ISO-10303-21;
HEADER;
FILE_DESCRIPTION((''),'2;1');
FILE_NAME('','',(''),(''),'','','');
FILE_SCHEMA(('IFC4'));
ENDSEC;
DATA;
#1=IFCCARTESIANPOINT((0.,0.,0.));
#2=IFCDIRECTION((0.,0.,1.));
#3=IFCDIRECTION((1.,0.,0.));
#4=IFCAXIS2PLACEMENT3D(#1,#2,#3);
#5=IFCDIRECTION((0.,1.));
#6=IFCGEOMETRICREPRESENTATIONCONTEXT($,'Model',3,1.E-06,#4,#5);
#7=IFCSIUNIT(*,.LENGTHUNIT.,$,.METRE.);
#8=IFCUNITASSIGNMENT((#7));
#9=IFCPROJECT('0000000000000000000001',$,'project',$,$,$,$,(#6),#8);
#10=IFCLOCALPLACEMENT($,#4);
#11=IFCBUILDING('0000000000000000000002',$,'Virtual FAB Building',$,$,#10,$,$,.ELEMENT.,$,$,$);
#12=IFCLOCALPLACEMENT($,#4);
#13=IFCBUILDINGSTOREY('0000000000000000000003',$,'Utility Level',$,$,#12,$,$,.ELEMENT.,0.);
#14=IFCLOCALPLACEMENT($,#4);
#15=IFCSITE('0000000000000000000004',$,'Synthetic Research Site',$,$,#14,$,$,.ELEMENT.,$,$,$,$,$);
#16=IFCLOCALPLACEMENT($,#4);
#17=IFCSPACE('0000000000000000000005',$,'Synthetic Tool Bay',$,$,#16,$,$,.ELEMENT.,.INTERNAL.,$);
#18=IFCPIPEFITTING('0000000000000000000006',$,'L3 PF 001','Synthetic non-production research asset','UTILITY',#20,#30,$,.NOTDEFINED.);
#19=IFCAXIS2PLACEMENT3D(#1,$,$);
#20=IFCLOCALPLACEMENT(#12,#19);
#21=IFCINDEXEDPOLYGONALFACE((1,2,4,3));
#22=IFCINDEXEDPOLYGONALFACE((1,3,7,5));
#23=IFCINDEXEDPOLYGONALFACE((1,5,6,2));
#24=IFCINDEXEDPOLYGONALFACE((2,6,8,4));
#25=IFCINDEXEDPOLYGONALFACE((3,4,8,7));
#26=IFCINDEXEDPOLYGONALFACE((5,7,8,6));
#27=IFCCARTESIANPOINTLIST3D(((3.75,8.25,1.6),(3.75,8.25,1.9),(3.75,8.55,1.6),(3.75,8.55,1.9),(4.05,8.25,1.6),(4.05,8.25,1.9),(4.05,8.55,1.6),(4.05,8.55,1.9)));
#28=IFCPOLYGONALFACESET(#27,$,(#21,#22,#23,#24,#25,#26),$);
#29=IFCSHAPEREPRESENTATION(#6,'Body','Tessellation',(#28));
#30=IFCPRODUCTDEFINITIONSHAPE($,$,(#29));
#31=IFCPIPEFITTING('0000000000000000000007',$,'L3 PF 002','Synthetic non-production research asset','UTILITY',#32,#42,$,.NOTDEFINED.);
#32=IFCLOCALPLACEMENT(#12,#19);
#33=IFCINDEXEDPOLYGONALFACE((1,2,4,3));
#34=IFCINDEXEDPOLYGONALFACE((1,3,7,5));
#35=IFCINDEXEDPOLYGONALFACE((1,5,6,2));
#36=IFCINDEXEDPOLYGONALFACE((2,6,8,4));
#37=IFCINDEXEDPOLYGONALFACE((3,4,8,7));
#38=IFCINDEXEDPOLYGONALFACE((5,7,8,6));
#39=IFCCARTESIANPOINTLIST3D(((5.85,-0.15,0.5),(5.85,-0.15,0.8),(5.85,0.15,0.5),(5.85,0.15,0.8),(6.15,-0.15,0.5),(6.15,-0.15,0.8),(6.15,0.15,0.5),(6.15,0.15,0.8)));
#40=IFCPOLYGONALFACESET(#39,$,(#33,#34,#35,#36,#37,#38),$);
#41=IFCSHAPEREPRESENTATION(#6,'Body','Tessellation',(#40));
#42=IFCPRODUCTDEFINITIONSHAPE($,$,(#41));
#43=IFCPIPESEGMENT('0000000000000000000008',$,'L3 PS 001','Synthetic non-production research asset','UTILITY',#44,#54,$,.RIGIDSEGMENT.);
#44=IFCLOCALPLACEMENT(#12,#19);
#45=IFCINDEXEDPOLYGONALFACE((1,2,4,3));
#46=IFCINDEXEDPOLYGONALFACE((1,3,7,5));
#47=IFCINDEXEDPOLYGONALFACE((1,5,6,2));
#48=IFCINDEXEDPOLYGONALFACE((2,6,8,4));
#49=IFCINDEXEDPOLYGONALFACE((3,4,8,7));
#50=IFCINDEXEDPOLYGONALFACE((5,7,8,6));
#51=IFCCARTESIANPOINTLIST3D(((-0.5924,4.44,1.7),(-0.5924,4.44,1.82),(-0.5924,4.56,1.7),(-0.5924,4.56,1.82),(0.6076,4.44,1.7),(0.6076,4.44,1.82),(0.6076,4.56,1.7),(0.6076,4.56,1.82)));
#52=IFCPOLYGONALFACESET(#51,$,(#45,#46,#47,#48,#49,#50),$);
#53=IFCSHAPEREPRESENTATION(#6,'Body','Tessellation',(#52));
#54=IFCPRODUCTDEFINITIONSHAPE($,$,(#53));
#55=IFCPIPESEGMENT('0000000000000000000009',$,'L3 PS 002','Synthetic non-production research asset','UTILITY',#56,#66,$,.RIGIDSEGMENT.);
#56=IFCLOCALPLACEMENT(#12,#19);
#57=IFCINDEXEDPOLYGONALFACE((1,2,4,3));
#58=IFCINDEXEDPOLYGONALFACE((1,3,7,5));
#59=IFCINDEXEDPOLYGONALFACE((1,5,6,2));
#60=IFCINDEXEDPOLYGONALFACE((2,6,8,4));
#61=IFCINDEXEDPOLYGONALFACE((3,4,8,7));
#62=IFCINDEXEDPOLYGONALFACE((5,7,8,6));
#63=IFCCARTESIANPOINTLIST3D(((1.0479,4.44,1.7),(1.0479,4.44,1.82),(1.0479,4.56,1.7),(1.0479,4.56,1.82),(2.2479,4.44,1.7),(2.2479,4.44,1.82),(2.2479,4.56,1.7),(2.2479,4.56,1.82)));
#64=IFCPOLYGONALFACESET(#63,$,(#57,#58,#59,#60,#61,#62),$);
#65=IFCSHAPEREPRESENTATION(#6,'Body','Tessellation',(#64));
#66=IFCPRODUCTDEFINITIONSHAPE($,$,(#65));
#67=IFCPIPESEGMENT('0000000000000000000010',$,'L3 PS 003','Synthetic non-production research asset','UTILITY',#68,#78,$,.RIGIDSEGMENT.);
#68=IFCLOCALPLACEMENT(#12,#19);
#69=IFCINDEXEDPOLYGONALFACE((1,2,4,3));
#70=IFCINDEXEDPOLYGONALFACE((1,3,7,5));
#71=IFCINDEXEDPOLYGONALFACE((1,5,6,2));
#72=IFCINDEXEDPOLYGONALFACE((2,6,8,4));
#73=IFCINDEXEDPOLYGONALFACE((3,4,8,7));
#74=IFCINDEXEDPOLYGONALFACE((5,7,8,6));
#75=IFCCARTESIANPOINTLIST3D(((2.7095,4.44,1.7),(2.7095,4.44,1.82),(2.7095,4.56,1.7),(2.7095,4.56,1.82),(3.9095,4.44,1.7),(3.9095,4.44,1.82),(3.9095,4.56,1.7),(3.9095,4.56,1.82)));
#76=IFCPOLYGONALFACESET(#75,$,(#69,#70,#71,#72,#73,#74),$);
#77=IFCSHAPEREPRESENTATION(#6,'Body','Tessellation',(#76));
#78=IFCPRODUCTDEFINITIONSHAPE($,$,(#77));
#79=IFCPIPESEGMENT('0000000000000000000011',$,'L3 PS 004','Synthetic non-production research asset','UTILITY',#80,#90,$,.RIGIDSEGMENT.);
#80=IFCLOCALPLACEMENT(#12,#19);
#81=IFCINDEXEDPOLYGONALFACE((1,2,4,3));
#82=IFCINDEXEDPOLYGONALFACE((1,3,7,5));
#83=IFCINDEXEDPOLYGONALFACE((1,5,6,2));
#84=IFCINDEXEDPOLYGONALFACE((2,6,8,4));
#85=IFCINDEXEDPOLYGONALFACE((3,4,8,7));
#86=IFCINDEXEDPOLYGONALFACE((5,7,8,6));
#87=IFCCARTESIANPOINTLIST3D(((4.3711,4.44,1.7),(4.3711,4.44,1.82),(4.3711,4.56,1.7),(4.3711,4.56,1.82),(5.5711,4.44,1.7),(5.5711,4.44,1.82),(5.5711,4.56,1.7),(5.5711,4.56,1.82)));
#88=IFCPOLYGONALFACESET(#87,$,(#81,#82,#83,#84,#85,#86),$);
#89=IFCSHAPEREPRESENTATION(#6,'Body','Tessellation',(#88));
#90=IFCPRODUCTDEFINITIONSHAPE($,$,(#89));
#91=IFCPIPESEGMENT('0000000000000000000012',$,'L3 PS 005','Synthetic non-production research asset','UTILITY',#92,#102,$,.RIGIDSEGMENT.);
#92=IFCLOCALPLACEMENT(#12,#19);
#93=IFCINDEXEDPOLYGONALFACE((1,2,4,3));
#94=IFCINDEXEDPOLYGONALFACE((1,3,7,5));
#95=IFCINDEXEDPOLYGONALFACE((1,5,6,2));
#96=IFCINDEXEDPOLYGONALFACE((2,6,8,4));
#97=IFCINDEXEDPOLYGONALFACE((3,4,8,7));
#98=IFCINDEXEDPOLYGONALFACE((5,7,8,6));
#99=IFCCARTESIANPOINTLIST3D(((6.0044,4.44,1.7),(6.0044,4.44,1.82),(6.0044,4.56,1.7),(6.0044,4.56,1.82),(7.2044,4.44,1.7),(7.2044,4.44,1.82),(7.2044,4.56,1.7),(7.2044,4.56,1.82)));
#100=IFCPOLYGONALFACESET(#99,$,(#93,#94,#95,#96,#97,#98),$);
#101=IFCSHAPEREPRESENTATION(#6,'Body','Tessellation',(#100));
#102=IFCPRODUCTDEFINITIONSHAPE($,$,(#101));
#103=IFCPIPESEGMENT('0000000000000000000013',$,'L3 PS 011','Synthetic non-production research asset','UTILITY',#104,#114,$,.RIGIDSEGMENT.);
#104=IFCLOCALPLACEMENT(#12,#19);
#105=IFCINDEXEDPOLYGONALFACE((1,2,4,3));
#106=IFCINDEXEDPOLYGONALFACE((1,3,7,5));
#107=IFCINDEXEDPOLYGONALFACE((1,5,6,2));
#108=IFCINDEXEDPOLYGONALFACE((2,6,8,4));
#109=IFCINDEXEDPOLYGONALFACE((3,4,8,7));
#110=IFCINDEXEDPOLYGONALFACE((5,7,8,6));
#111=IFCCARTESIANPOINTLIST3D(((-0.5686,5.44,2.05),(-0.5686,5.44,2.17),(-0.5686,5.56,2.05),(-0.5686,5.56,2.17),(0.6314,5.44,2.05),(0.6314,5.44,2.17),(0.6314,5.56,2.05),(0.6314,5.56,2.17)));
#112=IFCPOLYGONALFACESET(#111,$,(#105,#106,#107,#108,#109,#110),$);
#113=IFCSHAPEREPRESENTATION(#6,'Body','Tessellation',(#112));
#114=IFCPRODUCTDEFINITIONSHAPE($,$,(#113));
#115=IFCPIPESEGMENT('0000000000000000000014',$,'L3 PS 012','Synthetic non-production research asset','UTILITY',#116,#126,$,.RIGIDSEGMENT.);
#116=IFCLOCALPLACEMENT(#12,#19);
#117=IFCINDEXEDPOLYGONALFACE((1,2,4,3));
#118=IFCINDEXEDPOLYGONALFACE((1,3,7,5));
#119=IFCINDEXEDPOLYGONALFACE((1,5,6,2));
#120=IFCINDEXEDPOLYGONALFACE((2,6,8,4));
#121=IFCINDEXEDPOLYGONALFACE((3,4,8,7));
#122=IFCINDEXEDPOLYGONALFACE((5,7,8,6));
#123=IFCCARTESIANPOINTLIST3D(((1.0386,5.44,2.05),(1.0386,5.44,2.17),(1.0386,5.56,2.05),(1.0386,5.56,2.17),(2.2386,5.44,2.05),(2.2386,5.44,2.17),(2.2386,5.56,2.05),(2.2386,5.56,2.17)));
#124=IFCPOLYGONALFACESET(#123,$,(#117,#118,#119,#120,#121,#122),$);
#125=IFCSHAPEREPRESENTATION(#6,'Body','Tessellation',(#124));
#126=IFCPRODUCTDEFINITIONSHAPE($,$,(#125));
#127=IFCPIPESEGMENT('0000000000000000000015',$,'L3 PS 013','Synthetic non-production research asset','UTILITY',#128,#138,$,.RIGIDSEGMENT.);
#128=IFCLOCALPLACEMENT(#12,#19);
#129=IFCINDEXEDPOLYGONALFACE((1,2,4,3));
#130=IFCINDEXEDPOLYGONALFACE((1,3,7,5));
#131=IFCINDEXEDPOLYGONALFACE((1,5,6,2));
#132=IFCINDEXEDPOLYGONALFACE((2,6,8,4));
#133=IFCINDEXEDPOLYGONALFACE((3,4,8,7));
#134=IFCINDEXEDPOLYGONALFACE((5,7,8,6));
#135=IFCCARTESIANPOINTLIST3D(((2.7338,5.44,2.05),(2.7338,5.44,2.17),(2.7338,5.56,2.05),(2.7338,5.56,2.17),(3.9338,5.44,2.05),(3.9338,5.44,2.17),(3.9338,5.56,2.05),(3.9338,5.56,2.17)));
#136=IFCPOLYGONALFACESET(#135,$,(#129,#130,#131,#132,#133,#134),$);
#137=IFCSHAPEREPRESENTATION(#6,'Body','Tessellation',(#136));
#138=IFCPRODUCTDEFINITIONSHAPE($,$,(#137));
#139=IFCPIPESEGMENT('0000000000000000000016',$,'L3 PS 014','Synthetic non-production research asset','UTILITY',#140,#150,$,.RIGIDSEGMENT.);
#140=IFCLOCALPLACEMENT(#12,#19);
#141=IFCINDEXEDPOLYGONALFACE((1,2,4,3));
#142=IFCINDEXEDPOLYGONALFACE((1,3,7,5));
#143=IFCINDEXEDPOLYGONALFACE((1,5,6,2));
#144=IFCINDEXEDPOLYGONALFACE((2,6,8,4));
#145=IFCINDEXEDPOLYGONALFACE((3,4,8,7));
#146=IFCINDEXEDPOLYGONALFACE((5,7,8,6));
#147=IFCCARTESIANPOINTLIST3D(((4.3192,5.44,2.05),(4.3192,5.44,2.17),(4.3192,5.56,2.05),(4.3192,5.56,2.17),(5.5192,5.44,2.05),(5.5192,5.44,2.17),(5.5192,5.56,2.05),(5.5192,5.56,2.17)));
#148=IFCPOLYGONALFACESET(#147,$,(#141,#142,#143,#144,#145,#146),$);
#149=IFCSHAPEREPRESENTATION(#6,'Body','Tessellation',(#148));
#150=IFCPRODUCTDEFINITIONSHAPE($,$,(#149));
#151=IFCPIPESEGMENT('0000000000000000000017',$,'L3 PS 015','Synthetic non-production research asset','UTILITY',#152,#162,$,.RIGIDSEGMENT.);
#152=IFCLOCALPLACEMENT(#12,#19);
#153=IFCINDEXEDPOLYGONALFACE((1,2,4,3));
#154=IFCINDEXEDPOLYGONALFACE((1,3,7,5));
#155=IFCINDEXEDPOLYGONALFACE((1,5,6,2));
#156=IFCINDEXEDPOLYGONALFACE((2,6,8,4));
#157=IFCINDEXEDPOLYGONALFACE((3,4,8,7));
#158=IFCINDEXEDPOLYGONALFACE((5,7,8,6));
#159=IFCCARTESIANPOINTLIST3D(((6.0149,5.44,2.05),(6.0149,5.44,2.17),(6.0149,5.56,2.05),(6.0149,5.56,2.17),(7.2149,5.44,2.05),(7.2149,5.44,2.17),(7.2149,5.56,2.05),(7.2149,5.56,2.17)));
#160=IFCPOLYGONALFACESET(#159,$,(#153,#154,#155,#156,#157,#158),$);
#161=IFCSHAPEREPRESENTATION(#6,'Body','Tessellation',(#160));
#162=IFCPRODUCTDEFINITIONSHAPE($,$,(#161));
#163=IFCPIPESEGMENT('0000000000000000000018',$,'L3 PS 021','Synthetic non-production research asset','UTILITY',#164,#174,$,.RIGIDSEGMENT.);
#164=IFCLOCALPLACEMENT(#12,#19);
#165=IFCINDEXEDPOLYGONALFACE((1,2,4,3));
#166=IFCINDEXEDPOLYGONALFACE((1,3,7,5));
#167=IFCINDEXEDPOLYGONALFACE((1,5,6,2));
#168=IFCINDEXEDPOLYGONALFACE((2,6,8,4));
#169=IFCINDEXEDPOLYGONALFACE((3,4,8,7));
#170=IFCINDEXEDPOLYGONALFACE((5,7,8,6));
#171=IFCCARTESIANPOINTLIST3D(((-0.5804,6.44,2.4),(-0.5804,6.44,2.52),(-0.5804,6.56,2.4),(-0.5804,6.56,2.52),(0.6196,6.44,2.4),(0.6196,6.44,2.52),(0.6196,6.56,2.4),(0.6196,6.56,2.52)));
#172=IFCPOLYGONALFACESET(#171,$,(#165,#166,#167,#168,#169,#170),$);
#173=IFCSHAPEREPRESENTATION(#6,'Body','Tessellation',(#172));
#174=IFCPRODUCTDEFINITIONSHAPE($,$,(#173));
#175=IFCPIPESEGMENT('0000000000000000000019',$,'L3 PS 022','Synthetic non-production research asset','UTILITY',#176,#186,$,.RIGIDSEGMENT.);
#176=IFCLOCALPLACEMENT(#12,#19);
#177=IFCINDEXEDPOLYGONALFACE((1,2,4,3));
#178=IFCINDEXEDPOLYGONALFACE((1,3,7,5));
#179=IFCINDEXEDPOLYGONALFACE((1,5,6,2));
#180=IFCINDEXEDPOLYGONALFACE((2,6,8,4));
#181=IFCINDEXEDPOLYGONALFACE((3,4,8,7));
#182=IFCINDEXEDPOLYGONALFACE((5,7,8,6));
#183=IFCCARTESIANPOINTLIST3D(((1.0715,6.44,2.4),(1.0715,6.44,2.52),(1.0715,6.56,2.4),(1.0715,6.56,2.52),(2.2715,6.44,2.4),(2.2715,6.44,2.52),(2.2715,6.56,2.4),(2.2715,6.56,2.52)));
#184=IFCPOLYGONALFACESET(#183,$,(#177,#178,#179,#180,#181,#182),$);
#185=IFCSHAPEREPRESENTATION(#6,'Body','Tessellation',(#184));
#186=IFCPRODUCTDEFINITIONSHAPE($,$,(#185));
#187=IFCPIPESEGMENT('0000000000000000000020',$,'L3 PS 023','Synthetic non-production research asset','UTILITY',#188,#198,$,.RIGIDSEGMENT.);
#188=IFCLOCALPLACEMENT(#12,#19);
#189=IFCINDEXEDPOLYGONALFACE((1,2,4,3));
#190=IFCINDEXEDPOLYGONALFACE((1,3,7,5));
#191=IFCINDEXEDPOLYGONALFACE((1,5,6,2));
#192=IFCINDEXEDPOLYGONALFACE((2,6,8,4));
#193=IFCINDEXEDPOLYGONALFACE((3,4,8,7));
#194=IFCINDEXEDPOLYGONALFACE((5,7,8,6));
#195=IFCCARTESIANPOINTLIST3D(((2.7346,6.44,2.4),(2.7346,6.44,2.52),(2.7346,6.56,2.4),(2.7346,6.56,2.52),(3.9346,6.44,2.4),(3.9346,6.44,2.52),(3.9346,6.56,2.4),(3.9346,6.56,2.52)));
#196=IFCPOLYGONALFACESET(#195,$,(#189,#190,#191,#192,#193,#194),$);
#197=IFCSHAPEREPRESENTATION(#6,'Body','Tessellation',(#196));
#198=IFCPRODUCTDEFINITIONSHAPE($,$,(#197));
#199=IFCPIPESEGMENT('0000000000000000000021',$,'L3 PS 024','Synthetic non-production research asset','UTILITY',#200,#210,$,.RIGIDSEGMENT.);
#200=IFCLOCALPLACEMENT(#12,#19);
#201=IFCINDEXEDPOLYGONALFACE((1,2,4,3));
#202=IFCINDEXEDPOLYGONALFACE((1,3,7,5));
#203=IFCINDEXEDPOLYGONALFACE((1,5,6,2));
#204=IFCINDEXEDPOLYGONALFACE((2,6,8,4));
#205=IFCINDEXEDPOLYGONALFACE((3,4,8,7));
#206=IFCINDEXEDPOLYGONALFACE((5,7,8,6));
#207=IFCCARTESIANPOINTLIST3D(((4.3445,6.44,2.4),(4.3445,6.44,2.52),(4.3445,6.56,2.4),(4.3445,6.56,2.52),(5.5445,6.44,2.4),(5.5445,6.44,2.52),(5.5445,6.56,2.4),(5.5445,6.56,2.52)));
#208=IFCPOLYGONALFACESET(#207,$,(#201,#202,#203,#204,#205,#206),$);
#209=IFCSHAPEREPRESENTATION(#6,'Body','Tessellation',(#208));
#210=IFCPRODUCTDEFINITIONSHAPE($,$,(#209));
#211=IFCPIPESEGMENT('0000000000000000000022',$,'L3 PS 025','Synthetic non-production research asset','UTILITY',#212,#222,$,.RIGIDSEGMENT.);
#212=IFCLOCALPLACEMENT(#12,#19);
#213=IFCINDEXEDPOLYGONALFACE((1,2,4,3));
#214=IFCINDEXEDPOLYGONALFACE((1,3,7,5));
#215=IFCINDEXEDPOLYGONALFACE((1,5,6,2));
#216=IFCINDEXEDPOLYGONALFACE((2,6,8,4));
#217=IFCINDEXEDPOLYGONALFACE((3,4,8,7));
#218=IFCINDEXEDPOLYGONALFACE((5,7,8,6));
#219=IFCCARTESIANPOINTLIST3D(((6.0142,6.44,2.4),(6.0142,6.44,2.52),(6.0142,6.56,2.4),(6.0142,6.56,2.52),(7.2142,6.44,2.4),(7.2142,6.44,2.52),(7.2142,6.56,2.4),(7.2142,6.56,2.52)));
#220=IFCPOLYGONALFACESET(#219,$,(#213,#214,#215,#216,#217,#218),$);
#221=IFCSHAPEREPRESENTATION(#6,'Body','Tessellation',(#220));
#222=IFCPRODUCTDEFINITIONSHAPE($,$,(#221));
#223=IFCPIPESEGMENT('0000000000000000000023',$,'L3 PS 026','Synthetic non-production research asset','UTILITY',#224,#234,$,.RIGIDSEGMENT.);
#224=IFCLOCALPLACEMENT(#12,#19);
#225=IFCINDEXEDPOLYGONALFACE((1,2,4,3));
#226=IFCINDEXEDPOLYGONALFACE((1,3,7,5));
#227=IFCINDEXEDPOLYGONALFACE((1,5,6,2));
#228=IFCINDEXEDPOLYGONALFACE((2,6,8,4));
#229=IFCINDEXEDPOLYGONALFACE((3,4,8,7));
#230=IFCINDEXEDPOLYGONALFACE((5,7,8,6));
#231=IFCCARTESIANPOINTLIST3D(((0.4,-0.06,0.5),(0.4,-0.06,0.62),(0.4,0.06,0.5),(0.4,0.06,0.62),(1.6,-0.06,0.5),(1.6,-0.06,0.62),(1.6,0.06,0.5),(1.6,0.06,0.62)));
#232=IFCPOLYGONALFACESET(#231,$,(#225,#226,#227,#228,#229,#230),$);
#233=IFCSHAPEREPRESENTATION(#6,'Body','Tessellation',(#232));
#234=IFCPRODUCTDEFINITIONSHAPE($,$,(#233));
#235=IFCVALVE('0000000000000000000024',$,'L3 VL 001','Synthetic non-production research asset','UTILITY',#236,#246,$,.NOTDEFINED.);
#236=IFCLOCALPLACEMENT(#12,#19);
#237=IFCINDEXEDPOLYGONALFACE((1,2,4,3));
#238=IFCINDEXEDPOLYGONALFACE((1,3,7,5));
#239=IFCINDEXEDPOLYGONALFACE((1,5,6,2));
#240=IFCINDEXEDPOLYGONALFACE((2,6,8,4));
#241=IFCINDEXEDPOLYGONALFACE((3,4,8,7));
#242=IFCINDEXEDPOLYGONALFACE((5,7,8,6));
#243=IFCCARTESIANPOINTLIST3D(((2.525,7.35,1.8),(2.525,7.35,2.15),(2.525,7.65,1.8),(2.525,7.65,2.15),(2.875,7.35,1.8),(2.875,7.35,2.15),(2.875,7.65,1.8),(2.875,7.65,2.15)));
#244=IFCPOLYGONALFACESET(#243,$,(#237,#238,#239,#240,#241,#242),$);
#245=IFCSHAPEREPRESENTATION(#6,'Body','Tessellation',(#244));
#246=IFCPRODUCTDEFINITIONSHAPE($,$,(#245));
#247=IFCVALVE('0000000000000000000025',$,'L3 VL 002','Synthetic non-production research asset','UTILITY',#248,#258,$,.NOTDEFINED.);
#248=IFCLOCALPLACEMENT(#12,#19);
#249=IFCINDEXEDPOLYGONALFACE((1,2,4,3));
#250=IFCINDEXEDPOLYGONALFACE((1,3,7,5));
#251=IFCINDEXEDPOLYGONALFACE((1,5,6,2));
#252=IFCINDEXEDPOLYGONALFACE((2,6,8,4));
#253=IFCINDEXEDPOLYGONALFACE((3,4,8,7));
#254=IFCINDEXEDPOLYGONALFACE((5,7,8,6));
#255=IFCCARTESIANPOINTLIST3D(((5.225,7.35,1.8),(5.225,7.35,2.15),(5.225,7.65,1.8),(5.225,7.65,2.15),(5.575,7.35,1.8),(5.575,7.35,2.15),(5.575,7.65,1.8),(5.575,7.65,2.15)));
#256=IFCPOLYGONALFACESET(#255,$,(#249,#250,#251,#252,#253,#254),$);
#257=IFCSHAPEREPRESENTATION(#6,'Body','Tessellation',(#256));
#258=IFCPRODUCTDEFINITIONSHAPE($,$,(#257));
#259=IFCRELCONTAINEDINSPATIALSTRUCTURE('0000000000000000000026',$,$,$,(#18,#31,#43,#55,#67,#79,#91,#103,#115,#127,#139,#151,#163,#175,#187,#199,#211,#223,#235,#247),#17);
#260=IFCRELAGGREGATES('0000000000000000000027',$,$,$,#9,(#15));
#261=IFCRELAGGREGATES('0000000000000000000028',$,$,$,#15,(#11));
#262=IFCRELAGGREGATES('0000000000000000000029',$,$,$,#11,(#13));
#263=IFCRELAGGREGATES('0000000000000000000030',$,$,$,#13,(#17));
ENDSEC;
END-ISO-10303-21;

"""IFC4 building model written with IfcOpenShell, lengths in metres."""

from ifc_helpers import new_model, si_unit, direction, frame, origin_with_axes, origin_2d_with_axis, place, context, project, spatial, rectangle, extrude, element, save


model = new_model("IFC4")

# Units and contexts
model_context = context("Model", 3, precision=1e-06, world=origin_with_axes(), true_north=direction((0.0, 1.0)))
ifc_project = project(units=[si_unit("LENGTHUNIT", "METRE")], contexts=[model_context])

# Site, building, storey, space
site_placement = place(None, origin_with_axes())
site = spatial("IfcSite", under=ifc_project, at=site_placement, Name="Synthetic Research Site", CompositionType="ELEMENT")
building_placement = place(None, origin_with_axes())
building = spatial("IfcBuilding", under=site, at=building_placement, Name="Virtual FAB Building", CompositionType="ELEMENT")
storey_placement = place(None, origin_with_axes())
storey = spatial("IfcBuildingStorey", under=building, at=storey_placement, Name="Utility Level", CompositionType="ELEMENT", Elevation=0.0)
space_placement = place(None, origin_with_axes())
space = spatial("IfcSpace", under=storey, at=space_placement, Name="Synthetic Tool Bay", CompositionType="ELEMENT", PredefinedType="INTERNAL")

# Pipe fittings
for number, where, z_axis, x_axis, name in (
    (1, (3.9, 8.4, 1.6), (0.0, 0.0, 1.0), (1.0, 0.0, 0.0), "L3 PF 001"),
    (2, (6.0, 0.0, 0.5), (0.0, 0.0, 1.0), (1.0, 0.0, 0.0), "L3 PF 002"),
):
    element("IfcPipeFitting", number, at=place(None, frame(where, z_axis=z_axis, x_axis=x_axis)), inside=space, Name=name, Description="Synthetic non-production research asset", ObjectType="UTILITY", PredefinedType="NOTDEFINED", context=model_context, shape_type="SweptSolid", body=[
        extrude(rectangle(XDim=0.3, YDim=0.3, at=origin_2d_with_axis()), origin_with_axes(), (0.0, 0.0, 1.0), 0.3),
    ])

# Pipe segments
for number, where, z_axis, x_axis, name in (
    (3, (0.0076, 4.5, 1.7), (0.0, 0.0, 1.0), (1.0, 0.0, 0.0), "L3 PS 001"),
    (4, (1.6479, 4.5, 1.7), (0.0, 0.0, 1.0), (1.0, 0.0, 0.0), "L3 PS 002"),
    (5, (3.3095, 4.5, 1.7), (0.0, 0.0, 1.0), (1.0, 0.0, 0.0), "L3 PS 003"),
    (6, (4.9711, 4.5, 1.7), (0.0, 0.0, 1.0), (1.0, 0.0, 0.0), "L3 PS 004"),
    (7, (6.6044, 4.5, 1.7), (0.0, 0.0, 1.0), (1.0, 0.0, 0.0), "L3 PS 005"),
    (8, (0.0314, 5.5, 2.05), (0.0, 0.0, 1.0), (1.0, 0.0, 0.0), "L3 PS 011"),
    (9, (1.6386, 5.5, 2.05), (0.0, 0.0, 1.0), (1.0, 0.0, 0.0), "L3 PS 012"),
    (10, (3.3338, 5.5, 2.05), (0.0, 0.0, 1.0), (1.0, 0.0, 0.0), "L3 PS 013"),
    (11, (4.9192, 5.5, 2.05), (0.0, 0.0, 1.0), (1.0, 0.0, 0.0), "L3 PS 014"),
    (12, (6.6149, 5.5, 2.05), (0.0, 0.0, 1.0), (1.0, 0.0, 0.0), "L3 PS 015"),
    (13, (0.0196, 6.5, 2.4), (0.0, 0.0, 1.0), (1.0, 0.0, 0.0), "L3 PS 021"),
    (14, (1.6715, 6.5, 2.4), (0.0, 0.0, 1.0), (1.0, 0.0, 0.0), "L3 PS 022"),
    (15, (3.3346, 6.5, 2.4), (0.0, 0.0, 1.0), (1.0, 0.0, 0.0), "L3 PS 023"),
    (16, (4.9445, 6.5, 2.4), (0.0, 0.0, 1.0), (1.0, 0.0, 0.0), "L3 PS 024"),
    (17, (6.6142, 6.5, 2.4), (0.0, 0.0, 1.0), (1.0, 0.0, 0.0), "L3 PS 025"),
    (18, (1.0, 0.0, 0.5), (0.0, 0.0, 1.0), (1.0, 0.0, 0.0), "L3 PS 026"),
):
    element("IfcPipeSegment", number, at=place(None, frame(where, z_axis=z_axis, x_axis=x_axis)), inside=space, Name=name, Description="Synthetic non-production research asset", ObjectType="UTILITY", PredefinedType="RIGIDSEGMENT", context=model_context, shape_type="SweptSolid", body=[
        extrude(rectangle(XDim=1.2, YDim=0.12, at=origin_2d_with_axis()), origin_with_axes(), (0.0, 0.0, 1.0), 0.12),
    ])

# Valves
for number, where, z_axis, x_axis, name in (
    (19, (2.7, 7.5, 1.8), (0.0, 0.0, 1.0), (1.0, 0.0, 0.0), "L3 VL 001"),
    (20, (5.4, 7.5, 1.8), (0.0, 0.0, 1.0), (1.0, 0.0, 0.0), "L3 VL 002"),
):
    element("IfcValve", number, at=place(None, frame(where, z_axis=z_axis, x_axis=x_axis)), inside=space, Name=name, Description="Synthetic non-production research asset", ObjectType="UTILITY", PredefinedType="NOTDEFINED", context=model_context, shape_type="SweptSolid", body=[
        extrude(rectangle(XDim=0.35, YDim=0.3, at=origin_2d_with_axis()), origin_with_axes(), (0.0, 0.0, 1.0), 0.35),
    ])

save(model, "model.ifc")
